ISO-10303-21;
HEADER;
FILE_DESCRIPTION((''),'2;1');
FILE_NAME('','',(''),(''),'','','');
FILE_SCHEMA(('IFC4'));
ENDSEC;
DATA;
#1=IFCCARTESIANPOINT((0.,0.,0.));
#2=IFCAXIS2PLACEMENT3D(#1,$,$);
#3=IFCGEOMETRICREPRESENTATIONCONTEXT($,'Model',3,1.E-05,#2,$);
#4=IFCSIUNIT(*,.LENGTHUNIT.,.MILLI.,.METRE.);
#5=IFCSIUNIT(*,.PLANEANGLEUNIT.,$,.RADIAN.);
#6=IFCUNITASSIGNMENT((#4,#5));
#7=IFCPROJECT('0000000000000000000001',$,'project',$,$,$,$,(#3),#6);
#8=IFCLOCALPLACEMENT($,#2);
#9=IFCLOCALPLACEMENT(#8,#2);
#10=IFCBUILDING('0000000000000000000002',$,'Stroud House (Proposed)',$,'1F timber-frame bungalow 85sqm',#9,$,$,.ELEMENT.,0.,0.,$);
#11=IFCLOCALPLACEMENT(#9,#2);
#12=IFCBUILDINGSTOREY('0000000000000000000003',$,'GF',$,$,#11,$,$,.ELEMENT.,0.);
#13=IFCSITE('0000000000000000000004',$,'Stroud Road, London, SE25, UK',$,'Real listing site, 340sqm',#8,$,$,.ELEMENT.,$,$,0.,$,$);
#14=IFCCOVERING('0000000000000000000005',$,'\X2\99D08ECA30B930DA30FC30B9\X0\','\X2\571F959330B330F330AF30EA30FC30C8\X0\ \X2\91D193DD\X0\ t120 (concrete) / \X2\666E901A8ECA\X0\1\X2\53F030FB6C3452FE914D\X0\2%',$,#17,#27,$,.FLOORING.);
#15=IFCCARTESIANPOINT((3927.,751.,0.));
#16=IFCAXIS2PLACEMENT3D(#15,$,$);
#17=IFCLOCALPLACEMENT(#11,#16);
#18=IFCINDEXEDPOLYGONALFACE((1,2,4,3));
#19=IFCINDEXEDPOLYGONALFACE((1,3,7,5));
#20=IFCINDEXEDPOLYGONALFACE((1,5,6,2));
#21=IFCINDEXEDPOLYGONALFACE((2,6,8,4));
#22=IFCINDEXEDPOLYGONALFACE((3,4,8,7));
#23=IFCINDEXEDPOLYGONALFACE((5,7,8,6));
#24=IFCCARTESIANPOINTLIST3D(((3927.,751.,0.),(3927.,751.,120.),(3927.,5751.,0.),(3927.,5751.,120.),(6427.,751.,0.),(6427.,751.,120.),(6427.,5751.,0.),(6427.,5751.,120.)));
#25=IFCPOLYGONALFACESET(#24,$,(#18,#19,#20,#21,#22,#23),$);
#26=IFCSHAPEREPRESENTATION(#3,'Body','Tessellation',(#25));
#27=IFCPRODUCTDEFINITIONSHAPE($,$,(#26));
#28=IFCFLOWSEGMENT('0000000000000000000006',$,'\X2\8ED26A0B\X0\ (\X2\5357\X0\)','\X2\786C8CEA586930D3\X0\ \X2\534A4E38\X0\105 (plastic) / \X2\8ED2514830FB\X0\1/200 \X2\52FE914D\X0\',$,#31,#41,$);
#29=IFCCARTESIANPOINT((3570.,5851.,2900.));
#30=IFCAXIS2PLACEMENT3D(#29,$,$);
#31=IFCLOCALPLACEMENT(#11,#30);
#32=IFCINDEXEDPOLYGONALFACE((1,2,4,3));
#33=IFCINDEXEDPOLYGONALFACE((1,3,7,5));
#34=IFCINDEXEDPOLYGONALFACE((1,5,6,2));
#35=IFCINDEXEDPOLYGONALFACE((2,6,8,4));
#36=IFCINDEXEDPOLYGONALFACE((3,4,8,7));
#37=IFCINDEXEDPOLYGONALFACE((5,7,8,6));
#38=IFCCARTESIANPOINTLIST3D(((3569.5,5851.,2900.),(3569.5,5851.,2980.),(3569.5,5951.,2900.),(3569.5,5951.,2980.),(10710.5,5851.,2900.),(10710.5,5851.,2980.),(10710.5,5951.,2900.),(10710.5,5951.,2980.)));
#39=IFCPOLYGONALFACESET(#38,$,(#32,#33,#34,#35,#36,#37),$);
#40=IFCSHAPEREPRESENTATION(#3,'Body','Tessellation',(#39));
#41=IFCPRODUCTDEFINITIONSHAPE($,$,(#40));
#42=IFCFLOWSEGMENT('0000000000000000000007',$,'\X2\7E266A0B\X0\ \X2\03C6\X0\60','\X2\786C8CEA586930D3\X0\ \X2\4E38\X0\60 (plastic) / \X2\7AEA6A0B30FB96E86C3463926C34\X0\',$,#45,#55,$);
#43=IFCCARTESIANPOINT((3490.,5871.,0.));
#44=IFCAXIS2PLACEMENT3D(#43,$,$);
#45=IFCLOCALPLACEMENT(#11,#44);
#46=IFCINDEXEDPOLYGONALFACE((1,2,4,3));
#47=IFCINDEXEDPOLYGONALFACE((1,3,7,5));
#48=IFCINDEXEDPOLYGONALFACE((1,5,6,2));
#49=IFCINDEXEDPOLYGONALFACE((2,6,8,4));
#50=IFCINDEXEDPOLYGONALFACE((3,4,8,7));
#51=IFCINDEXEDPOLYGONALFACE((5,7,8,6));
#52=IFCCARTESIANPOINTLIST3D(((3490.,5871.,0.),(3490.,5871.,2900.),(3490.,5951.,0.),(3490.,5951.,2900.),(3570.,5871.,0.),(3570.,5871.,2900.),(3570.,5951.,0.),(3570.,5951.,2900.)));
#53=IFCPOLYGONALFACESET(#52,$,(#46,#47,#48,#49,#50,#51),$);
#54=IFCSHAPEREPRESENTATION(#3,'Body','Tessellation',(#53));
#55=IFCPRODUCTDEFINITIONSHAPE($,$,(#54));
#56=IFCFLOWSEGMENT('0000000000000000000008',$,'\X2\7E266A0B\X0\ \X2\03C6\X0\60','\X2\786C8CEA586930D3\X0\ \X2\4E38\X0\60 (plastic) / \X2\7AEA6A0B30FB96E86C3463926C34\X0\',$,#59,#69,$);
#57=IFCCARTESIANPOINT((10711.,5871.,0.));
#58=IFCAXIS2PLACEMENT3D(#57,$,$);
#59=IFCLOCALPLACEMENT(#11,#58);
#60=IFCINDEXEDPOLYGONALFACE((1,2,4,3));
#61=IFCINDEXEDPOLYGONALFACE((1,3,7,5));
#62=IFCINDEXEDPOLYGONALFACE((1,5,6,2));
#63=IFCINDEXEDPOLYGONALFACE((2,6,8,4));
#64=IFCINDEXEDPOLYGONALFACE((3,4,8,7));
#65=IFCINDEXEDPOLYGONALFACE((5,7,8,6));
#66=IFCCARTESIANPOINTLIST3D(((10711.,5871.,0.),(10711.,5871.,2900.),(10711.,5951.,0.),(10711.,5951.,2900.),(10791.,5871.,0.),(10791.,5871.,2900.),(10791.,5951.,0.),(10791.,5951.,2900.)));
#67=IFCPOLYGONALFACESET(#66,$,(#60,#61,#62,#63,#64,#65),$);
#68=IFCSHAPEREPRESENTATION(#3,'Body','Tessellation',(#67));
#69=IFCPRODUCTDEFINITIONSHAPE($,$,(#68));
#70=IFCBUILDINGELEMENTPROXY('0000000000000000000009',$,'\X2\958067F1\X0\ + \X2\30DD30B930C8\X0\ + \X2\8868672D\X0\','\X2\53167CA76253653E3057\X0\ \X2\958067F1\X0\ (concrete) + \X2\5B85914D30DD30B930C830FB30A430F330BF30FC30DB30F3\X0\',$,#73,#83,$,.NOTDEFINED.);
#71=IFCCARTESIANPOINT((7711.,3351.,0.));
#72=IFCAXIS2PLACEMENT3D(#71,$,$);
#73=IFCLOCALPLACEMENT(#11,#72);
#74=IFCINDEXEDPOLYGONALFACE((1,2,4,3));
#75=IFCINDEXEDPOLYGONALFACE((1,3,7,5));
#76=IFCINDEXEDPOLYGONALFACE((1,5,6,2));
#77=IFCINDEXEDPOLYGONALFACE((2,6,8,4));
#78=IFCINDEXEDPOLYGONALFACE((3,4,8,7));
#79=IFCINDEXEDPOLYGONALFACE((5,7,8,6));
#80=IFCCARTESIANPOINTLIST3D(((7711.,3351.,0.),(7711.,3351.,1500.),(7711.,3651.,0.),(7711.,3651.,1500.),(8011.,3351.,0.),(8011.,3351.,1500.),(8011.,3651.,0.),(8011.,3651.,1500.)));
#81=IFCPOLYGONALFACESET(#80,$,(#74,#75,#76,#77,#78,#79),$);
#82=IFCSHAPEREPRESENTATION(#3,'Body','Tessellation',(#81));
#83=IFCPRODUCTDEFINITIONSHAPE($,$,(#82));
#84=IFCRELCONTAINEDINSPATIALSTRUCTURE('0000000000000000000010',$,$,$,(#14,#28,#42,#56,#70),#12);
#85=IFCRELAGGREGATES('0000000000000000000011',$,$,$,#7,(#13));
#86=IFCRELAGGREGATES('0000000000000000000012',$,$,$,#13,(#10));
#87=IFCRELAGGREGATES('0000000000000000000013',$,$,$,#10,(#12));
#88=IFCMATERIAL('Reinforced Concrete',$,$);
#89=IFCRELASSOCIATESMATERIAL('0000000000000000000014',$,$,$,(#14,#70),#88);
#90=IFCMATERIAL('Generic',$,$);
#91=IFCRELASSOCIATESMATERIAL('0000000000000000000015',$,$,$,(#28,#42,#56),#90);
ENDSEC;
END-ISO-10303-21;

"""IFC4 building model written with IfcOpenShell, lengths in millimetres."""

from ifc_helpers import new_model, si_unit, frame, frame_2d, origin, place, context, project, spatial, rectangle, extrude, material, element, save


model = new_model("IFC4")

# Units and contexts
model_context = context("Model", 3, precision=1e-05, world=origin())
ifc_project = project(units=[si_unit("LENGTHUNIT", "METRE", prefix="MILLI"), si_unit("PLANEANGLEUNIT", "RADIAN")], contexts=[model_context])

# Site, building, storey
site_placement = place(None, origin())
site = spatial("IfcSite", under=ifc_project, at=site_placement, Name="Stroud Road, London, SE25, UK", ObjectType="Real listing site, 340sqm", CompositionType="ELEMENT", RefElevation=0.0)
building_placement = place(site_placement, origin())
building = spatial("IfcBuilding", under=site, at=building_placement, Name="Stroud House (Proposed)", ObjectType="1F timber-frame bungalow 85sqm", CompositionType="ELEMENT", ElevationOfRefHeight=0.0, ElevationOfTerrain=0.0)
storey_placement = place(building_placement, origin())
storey = spatial("IfcBuildingStorey", under=building, at=storey_placement, Name="GF", CompositionType="ELEMENT", Elevation=0.0)

# Shared definitions
ifc_material_1 = material(Name="Reinforced Concrete")

# Covering
covering_1_placement = place(storey_placement, frame((3927.0, 751.0, 0.0)))
element("IfcCovering", 1, at=covering_1_placement, inside=storey, material=ifc_material_1, Name="駐車スペース", Description="土間コンクリート 金鏝 t120 (concrete) / 普通車1台・水勾配2%", PredefinedType="FLOORING", context=model_context, shape_type="SweptSolid", body=[
    extrude(rectangle(XDim=2500.0, YDim=5000.0, at=frame_2d((1250.0, 2500.0))), frame((3927.0, 751.0, 0.0)), (0.0, 0.0, 1.0), 120.0),
])

# Flow segments
ifc_material_2 = material(Name="Generic")
flow_segment_1_placement = place(storey_placement, frame((3570.0, 5851.0, 2900.0)))
element("IfcFlowSegment", 2, at=flow_segment_1_placement, inside=storey, material=ifc_material_2, Name="軒樋 (南)", Description="硬質塩ビ 半丸105 (plastic) / 軒先・1/200 勾配", context=model_context, shape_type="SweptSolid", body=[
    extrude(rectangle(XDim=7141.0, YDim=100.0, at=frame_2d((3570.0, 50.0))), frame((3570.0, 5851.0, 2900.0)), (0.0, 0.0, 1.0), 80.0),
])
flow_segment_2_placement = place(storey_placement, frame((3490.0, 5871.0, 0.0)))
element("IfcFlowSegment", 3, at=flow_segment_2_placement, inside=storey, material=ifc_material_2, Name="縦樋 φ60", Description="硬質塩ビ 丸60 (plastic) / 竪樋・雨水排水", context=model_context, shape_type="SweptSolid", body=[
    extrude(rectangle(XDim=80.0, YDim=80.0, at=frame_2d((40.0, 40.0))), frame((3490.0, 5871.0, 0.0)), (0.0, 0.0, 1.0), 2900.0),
])
flow_segment_3_placement = place(storey_placement, frame((10711.0, 5871.0, 0.0)))
element("IfcFlowSegment", 4, at=flow_segment_3_placement, inside=storey, material=ifc_material_2, Name="縦樋 φ60", Description="硬質塩ビ 丸60 (plastic) / 竪樋・雨水排水", context=model_context, shape_type="SweptSolid", body=[
    extrude(rectangle(XDim=80.0, YDim=80.0, at=frame_2d((40.0, 40.0))), frame((10711.0, 5871.0, 0.0)), (0.0, 0.0, 1.0), 2900.0),
])

# Building element proxy
proxy_placement = place(storey_placement, frame((7711.0, 3351.0, 0.0)))
element("IfcBuildingElementProxy", 5, at=proxy_placement, inside=storey, material=ifc_material_1, Name="門柱 + ポスト + 表札", Description="化粧打放し 門柱 (concrete) + 宅配ポスト・インターホン", PredefinedType="NOTDEFINED", context=model_context, shape_type="SweptSolid", body=[
    extrude(rectangle(XDim=300.0, YDim=300.0, at=frame_2d((150.0, 150.0))), frame((7711.0, 3351.0, 0.0)), (0.0, 0.0, 1.0), 1500.0),
])

save(model, "model.ifc")
